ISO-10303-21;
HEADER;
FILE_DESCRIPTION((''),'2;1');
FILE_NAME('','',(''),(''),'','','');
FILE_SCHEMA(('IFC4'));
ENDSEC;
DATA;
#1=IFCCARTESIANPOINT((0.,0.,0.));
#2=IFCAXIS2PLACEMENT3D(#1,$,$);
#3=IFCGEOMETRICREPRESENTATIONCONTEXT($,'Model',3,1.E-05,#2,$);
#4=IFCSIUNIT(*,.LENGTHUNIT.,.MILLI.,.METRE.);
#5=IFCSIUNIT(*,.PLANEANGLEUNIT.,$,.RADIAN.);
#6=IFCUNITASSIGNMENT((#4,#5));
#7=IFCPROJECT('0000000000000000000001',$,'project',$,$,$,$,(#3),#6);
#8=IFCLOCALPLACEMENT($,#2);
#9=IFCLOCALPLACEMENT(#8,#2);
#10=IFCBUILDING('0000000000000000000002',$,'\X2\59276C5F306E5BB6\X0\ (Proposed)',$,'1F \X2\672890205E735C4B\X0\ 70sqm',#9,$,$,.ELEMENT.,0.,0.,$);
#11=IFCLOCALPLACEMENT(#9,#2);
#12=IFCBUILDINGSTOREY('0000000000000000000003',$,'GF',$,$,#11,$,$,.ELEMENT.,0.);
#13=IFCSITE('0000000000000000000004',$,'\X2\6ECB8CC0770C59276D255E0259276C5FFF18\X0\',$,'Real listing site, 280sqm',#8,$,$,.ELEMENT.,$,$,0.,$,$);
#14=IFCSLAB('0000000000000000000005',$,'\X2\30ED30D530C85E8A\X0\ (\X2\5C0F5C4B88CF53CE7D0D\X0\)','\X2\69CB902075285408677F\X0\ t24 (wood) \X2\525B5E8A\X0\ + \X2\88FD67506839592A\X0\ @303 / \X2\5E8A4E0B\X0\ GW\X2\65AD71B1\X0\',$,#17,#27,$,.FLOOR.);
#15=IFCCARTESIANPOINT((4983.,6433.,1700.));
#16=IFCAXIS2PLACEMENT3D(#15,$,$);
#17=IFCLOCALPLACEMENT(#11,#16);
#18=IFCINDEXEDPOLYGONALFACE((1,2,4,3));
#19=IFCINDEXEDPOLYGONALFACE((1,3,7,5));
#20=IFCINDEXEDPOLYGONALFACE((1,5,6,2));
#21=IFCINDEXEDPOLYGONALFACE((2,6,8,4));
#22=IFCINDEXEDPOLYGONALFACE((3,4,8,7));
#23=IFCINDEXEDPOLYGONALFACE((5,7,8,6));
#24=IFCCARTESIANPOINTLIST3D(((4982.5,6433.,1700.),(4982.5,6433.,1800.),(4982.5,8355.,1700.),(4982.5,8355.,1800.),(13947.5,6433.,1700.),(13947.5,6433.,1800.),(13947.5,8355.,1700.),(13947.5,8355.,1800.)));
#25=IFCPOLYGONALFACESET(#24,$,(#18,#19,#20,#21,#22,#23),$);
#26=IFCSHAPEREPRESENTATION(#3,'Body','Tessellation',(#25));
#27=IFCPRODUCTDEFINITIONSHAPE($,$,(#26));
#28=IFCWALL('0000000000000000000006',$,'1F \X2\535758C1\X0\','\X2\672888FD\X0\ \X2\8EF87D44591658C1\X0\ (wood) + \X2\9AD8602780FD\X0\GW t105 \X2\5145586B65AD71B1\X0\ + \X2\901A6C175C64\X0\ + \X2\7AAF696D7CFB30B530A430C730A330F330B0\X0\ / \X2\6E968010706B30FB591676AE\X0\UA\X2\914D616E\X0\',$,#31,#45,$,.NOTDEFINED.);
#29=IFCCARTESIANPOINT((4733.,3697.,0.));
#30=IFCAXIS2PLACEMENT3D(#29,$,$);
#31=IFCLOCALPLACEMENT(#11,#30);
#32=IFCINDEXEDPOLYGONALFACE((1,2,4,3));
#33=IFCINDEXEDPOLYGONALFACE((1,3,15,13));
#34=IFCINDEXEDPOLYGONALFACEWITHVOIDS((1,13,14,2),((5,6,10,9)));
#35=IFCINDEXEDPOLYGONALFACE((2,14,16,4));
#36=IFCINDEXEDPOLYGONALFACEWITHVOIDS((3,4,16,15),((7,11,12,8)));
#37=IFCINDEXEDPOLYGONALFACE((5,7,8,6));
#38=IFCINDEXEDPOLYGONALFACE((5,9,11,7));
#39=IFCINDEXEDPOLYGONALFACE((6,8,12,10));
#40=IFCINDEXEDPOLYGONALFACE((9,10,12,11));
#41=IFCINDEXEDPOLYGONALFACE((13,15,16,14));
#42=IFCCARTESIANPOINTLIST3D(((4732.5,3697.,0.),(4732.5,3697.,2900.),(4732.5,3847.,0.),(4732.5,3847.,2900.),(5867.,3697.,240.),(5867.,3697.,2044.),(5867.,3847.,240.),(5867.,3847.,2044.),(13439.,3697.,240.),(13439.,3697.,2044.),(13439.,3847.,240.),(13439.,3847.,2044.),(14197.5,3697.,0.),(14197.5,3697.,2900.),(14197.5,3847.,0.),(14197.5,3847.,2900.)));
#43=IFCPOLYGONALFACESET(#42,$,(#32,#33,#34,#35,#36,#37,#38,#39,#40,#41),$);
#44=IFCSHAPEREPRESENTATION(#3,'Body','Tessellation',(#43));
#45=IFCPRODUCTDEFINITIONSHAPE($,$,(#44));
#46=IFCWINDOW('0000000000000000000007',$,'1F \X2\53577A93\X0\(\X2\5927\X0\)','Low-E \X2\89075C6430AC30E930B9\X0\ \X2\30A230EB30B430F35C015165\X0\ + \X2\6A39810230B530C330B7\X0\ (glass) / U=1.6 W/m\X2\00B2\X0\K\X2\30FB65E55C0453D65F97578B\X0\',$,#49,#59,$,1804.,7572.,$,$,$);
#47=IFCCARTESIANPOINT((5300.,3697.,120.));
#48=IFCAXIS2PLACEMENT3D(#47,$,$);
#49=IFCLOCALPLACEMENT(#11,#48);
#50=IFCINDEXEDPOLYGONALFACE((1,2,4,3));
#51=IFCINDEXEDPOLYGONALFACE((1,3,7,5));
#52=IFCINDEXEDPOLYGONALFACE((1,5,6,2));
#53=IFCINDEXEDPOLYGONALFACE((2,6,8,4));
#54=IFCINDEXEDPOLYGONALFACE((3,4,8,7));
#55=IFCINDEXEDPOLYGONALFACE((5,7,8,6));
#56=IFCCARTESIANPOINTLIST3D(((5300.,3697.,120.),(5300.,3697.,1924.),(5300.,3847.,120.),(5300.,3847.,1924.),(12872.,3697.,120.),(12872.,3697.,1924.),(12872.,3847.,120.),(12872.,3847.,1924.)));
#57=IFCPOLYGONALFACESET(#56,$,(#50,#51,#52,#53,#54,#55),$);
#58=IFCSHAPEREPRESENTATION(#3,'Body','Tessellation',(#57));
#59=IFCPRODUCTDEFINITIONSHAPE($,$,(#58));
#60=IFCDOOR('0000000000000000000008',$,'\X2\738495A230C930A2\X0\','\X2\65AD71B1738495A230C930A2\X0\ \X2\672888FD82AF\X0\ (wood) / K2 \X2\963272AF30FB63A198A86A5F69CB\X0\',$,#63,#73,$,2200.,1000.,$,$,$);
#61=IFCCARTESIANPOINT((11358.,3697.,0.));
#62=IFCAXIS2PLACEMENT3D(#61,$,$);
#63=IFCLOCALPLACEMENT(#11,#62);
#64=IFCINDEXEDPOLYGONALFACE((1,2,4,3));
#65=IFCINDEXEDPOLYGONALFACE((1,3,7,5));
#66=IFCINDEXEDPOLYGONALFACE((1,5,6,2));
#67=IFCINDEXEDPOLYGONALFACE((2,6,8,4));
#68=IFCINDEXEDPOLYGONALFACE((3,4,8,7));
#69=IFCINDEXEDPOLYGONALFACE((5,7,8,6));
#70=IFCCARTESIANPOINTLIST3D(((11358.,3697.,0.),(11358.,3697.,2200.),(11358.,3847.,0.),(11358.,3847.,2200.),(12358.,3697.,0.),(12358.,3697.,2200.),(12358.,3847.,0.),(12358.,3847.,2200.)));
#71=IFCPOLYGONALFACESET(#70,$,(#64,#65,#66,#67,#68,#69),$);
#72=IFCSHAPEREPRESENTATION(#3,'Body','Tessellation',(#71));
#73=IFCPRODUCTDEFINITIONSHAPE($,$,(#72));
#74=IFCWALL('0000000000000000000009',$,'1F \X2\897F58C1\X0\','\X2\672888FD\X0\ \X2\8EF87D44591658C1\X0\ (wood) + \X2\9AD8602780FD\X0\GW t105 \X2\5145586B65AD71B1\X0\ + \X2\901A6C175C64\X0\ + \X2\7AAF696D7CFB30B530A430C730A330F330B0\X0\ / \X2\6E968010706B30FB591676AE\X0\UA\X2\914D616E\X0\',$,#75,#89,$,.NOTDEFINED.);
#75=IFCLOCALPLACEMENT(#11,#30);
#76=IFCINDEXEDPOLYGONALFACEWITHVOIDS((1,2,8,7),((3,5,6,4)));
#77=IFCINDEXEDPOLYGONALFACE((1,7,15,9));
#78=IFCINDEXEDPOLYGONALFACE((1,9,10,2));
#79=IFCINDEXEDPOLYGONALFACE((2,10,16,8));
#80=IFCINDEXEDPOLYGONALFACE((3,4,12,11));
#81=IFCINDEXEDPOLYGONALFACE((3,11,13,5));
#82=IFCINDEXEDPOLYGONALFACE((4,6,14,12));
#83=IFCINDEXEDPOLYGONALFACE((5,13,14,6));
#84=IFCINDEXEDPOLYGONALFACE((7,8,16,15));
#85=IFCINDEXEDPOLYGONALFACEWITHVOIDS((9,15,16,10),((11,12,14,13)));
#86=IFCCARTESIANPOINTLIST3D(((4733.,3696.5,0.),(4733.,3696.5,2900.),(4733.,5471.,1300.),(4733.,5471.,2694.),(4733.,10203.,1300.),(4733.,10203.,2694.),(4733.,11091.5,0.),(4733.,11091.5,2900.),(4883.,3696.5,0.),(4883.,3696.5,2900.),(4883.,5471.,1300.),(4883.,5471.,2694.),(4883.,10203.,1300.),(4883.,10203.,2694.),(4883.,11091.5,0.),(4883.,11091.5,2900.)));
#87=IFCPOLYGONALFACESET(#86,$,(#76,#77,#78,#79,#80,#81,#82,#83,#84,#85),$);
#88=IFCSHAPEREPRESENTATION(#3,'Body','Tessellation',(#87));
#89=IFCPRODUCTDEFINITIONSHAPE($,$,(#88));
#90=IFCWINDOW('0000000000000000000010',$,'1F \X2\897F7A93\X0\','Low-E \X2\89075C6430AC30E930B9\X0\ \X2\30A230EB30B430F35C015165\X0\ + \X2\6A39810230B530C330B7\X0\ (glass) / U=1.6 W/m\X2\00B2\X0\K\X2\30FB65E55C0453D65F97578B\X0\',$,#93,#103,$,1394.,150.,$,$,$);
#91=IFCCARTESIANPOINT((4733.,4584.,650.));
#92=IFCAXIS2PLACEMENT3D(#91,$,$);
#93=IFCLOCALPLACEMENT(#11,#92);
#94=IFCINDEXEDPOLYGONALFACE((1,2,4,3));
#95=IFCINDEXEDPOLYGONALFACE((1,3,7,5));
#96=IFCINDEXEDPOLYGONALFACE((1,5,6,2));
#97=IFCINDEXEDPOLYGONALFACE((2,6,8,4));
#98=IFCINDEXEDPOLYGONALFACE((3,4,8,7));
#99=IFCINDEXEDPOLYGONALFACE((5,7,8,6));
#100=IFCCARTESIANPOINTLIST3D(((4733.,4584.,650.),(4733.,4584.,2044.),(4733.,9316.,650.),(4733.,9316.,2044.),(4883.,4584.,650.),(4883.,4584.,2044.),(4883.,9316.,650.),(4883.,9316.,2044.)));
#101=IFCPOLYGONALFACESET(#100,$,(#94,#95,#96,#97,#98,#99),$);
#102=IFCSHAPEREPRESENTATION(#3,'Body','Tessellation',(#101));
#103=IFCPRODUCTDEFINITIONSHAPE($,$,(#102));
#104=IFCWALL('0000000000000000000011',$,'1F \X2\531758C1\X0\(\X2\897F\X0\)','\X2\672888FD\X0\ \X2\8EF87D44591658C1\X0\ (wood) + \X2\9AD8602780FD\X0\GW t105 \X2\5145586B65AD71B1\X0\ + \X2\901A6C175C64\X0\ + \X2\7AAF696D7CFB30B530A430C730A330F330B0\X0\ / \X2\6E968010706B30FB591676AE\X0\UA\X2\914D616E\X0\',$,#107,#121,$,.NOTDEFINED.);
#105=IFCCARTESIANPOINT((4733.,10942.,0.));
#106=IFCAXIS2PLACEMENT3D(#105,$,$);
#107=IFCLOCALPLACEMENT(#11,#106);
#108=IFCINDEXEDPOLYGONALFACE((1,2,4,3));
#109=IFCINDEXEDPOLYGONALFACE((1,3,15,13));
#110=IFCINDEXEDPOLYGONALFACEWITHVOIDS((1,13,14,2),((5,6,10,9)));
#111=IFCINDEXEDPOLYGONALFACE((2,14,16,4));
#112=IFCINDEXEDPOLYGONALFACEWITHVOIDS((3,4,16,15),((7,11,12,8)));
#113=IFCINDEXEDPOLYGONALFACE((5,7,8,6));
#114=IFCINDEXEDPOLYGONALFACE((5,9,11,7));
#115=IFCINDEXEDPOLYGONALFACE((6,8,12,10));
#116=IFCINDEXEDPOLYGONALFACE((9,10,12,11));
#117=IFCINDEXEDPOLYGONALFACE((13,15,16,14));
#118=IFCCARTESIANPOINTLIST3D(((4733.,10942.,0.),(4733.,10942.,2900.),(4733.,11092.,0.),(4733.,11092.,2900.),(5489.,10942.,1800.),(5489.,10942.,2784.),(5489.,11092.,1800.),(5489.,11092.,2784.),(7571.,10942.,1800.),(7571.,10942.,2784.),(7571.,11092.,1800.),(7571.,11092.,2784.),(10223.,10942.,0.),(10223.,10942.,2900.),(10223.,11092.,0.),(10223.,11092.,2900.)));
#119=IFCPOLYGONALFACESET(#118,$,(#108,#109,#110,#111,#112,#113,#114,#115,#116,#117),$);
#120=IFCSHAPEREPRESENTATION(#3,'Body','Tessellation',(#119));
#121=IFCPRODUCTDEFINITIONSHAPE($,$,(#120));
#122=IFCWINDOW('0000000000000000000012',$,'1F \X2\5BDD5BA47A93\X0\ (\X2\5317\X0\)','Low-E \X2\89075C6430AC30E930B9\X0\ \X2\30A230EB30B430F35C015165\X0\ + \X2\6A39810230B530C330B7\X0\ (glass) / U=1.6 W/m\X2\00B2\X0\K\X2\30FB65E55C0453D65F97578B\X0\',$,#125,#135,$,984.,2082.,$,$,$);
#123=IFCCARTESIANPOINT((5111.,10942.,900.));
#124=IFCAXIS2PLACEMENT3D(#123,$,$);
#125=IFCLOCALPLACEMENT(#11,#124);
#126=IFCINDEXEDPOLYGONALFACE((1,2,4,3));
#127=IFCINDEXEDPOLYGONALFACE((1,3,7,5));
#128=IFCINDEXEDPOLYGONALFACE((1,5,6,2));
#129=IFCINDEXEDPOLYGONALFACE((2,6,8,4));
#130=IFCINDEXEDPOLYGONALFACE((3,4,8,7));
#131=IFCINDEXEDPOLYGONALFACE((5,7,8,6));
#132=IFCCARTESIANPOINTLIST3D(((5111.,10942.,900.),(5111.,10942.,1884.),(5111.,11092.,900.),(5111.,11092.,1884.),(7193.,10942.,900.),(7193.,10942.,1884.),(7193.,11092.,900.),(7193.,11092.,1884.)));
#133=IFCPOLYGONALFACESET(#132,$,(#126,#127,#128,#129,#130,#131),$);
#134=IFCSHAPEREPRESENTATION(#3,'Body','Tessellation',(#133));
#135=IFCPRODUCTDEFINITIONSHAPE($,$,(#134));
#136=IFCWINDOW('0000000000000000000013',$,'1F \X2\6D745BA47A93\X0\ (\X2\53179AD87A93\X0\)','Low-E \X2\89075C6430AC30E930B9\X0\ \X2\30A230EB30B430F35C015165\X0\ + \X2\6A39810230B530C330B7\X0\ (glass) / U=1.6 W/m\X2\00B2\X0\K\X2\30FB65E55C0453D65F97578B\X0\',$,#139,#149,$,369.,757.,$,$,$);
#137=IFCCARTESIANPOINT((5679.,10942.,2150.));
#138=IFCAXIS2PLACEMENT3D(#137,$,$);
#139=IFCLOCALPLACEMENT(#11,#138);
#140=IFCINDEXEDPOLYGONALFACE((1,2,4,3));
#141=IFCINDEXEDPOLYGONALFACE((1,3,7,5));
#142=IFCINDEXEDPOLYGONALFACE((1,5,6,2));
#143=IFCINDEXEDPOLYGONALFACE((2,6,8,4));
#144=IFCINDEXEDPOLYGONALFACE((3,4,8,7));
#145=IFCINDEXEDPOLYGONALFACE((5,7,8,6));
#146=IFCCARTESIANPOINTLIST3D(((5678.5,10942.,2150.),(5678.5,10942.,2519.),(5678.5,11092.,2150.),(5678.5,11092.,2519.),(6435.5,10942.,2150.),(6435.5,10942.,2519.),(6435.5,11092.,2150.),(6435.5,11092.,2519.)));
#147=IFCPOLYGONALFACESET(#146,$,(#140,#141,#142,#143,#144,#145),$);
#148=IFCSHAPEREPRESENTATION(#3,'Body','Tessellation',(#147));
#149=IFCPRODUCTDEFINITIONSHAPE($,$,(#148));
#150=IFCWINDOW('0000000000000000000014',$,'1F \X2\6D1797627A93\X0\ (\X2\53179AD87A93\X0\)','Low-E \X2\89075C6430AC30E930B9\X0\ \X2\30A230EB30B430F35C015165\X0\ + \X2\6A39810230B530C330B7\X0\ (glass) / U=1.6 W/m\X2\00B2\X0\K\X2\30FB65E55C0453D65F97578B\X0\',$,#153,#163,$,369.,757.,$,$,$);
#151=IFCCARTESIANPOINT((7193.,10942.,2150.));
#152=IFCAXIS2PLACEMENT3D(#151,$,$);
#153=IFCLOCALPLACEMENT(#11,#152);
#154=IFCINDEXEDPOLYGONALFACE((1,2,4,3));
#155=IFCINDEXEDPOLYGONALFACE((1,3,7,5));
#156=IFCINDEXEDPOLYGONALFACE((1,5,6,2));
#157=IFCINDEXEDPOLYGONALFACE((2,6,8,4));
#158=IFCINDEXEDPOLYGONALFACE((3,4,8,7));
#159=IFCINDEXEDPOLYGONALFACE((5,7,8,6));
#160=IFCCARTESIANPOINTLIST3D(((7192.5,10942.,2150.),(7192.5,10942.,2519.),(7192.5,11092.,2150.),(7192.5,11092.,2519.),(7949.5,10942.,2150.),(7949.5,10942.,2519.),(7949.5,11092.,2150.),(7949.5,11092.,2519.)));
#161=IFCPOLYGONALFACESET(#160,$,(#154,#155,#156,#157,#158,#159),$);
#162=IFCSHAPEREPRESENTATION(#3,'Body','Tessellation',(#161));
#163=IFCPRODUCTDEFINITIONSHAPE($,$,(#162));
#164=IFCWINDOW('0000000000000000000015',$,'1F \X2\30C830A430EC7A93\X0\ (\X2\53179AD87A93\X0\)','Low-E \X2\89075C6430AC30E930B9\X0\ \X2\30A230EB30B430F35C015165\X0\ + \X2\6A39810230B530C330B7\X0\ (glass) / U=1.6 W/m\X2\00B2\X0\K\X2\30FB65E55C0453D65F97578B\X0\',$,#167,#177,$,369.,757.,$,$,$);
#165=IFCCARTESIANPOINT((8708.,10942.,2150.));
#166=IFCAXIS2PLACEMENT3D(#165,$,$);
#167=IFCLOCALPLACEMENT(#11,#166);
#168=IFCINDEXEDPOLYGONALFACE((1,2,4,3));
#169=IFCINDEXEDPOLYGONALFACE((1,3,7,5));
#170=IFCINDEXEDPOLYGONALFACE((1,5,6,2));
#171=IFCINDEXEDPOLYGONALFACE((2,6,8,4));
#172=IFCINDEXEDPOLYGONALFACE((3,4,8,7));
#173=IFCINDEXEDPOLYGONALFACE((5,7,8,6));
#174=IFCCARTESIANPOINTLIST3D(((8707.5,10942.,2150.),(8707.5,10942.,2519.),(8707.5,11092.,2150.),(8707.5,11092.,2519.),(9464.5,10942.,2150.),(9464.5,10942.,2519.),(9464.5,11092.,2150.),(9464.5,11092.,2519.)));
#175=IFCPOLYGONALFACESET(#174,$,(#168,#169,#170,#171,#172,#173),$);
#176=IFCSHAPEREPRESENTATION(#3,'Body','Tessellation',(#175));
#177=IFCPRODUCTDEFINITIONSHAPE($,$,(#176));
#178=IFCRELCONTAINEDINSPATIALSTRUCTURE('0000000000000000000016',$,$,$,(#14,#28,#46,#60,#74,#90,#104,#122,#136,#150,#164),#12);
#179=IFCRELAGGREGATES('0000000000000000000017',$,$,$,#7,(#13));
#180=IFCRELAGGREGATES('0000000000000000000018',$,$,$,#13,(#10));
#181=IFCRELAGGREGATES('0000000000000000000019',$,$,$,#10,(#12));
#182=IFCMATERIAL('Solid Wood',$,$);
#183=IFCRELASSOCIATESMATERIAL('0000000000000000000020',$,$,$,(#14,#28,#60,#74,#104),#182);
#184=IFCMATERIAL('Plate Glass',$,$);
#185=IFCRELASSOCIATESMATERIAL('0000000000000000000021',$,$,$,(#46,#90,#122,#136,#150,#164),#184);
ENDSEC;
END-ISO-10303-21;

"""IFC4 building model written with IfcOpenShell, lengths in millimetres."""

from ifc_helpers import new_model, si_unit, frame, frame_2d, origin, place, context, project, spatial, rectangle, extrude, material, element, fill, save


model = new_model("IFC4")

# Units and contexts
model_context = context("Model", 3, precision=1e-05, world=origin())
ifc_project = project(units=[si_unit("LENGTHUNIT", "METRE", prefix="MILLI"), si_unit("PLANEANGLEUNIT", "RADIAN")], contexts=[model_context])

# Site, building, storey
site_placement = place(None, origin())
site = spatial("IfcSite", under=ifc_project, at=site_placement, Name="滋賀県大津市大江８", ObjectType="Real listing site, 280sqm", CompositionType="ELEMENT", RefElevation=0.0)
building_placement = place(site_placement, origin())
building = spatial("IfcBuilding", under=site, at=building_placement, Name="大江の家 (Proposed)", ObjectType="1F 木造平屋 70sqm", CompositionType="ELEMENT", ElevationOfRefHeight=0.0, ElevationOfTerrain=0.0)
storey_placement = place(building_placement, origin())
storey = spatial("IfcBuildingStorey", under=building, at=storey_placement, Name="GF", CompositionType="ELEMENT", Elevation=0.0)

# Slab
ifc_material_1 = material(Name="Solid Wood")
slab_1_placement = place(storey_placement, frame((4983.0, 6433.0, 1700.0)))
element("IfcSlab", 1, at=slab_1_placement, inside=storey, material=ifc_material_1, Name="ロフト床 (小屋裏収納)", Description="構造用合板 t24 (wood) 剛床 + 製材根太 @303 / 床下 GW断熱", PredefinedType="FLOOR", context=model_context, shape_type="SweptSolid", body=[
    extrude(rectangle(XDim=8965.0, YDim=1922.0, at=frame_2d((4482.0, 961.0))), frame((4983.0, 6433.0, 1700.0)), (0.0, 0.0, 1.0), 100.0),
])

# Wall, openings, window, door
wall_1_placement = place(storey_placement, frame((4733.0, 3697.0, 0.0)))
wall_1 = element("IfcWall", 2, at=wall_1_placement, inside=storey, material=ifc_material_1, Name="1F 南壁", Description="木製 軸組外壁 (wood) + 高性能GW t105 充填断熱 + 通気層 + 窯業系サイディング / 準耐火・外皮UA配慮", PredefinedType="NOTDEFINED", context=model_context, shape_type="SweptSolid", body=[
    extrude(rectangle(XDim=9465.0, YDim=150.0, at=frame_2d((4732.0, 75.0))), frame((4733.0, 3697.0, 0.0)), (0.0, 0.0, 1.0), 2900.0),
])
opening_1_placement = place(storey_placement, frame((5300.0, 3697.0, 120.0)))
opening_1 = element("IfcOpeningElement", 3, at=opening_1_placement, cuts=wall_1, PredefinedType="NOTDEFINED", context=model_context, shape_type="SweptSolid", body=[
    extrude(rectangle(XDim=7572.0, YDim=150.0, at=frame_2d((3786.0, 75.0))), frame((5300.0, 3697.0, 120.0)), (0.0, 0.0, 1.0), 1804.0),
])
opening_2_placement = place(storey_placement, frame((11358.0, 3697.0, 0.0)))
opening_2 = element("IfcOpeningElement", 4, at=opening_2_placement, cuts=wall_1, PredefinedType="NOTDEFINED", context=model_context, shape_type="SweptSolid", body=[
    extrude(rectangle(XDim=1000.0, YDim=150.0, at=frame_2d((500.0, 75.0))), frame((11358.0, 3697.0, 0.0)), (0.0, 0.0, 1.0), 2200.0),
])
ifc_material_2 = material(Name="Plate Glass")
window_1_placement = place(storey_placement, frame((5300.0, 3697.0, 120.0)))
window_1 = element("IfcWindow", 5, at=window_1_placement, inside=storey, material=ifc_material_2, Name="1F 南窓(大)", Description="Low-E 複層ガラス アルゴン封入 + 樹脂サッシ (glass) / U=1.6 W/m²K・日射取得型", OverallHeight=1804.0, OverallWidth=7572.0, context=model_context, shape_type="SweptSolid", body=[
    extrude(rectangle(XDim=7572.0, YDim=150.0, at=frame_2d((3786.0, 75.0))), frame((5300.0, 3697.0, 120.0)), (0.0, 0.0, 1.0), 1804.0),
])
fill(opening_1, window_1)
door_placement = place(storey_placement, frame((11358.0, 3697.0, 0.0)))
door = element("IfcDoor", 6, at=door_placement, inside=storey, material=ifc_material_1, Name="玄関ドア", Description="断熱玄関ドア 木製芯 (wood) / K2 防犯・採風機構", OverallHeight=2200.0, OverallWidth=1000.0, context=model_context, shape_type="SweptSolid", body=[
    extrude(rectangle(XDim=1000.0, YDim=150.0, at=frame_2d((500.0, 75.0))), frame((11358.0, 3697.0, 0.0)), (0.0, 0.0, 1.0), 2200.0),
])
fill(opening_2, door)

# Wall, opening, window
wall_2_placement = place(storey_placement, frame((4733.0, 3697.0, 0.0)))
wall_2 = element("IfcWall", 7, at=wall_2_placement, inside=storey, material=ifc_material_1, Name="1F 西壁", Description="木製 軸組外壁 (wood) + 高性能GW t105 充填断熱 + 通気層 + 窯業系サイディング / 準耐火・外皮UA配慮", PredefinedType="NOTDEFINED", context=model_context, shape_type="SweptSolid", body=[
    extrude(rectangle(XDim=150.0, YDim=7395.0, at=frame_2d((75.0, 3697.0))), frame((4733.0, 3697.0, 0.0)), (0.0, 0.0, 1.0), 2900.0),
])
opening_3_placement = place(storey_placement, frame((4733.0, 4584.0, 650.0)))
opening_3 = element("IfcOpeningElement", 8, at=opening_3_placement, cuts=wall_2, PredefinedType="NOTDEFINED", context=model_context, shape_type="SweptSolid", body=[
    extrude(rectangle(XDim=150.0, YDim=4732.0, at=frame_2d((75.0, 2366.0))), frame((4733.0, 4584.0, 650.0)), (0.0, 0.0, 1.0), 1394.0),
])
window_2_placement = place(storey_placement, frame((4733.0, 4584.0, 650.0)))
window_2 = element("IfcWindow", 9, at=window_2_placement, inside=storey, material=ifc_material_2, Name="1F 西窓", Description="Low-E 複層ガラス アルゴン封入 + 樹脂サッシ (glass) / U=1.6 W/m²K・日射取得型", OverallHeight=1394.0, OverallWidth=150.0, context=model_context, shape_type="SweptSolid", body=[
    extrude(rectangle(XDim=150.0, YDim=4732.0, at=frame_2d((75.0, 2366.0))), frame((4733.0, 4584.0, 650.0)), (0.0, 0.0, 1.0), 1394.0),
])
fill(opening_3, window_2)

# Wall, openings, windows
wall_3_placement = place(storey_placement, frame((4733.0, 10942.0, 0.0)))
wall_3 = element("IfcWall", 10, at=wall_3_placement, inside=storey, material=ifc_material_1, Name="1F 北壁(西)", Description="木製 軸組外壁 (wood) + 高性能GW t105 充填断熱 + 通気層 + 窯業系サイディング / 準耐火・外皮UA配慮", PredefinedType="NOTDEFINED", context=model_context, shape_type="SweptSolid", body=[
    extrude(rectangle(XDim=5490.0, YDim=150.0, at=frame_2d((2745.0, 75.0))), frame((4733.0, 10942.0, 0.0)), (0.0, 0.0, 1.0), 2900.0),
])
opening_4_placement = place(storey_placement, frame((5111.0, 10942.0, 900.0)))
opening_4 = element("IfcOpeningElement", 11, at=opening_4_placement, cuts=wall_3, PredefinedType="NOTDEFINED", context=model_context, shape_type="SweptSolid", body=[
    extrude(rectangle(XDim=2082.0, YDim=150.0, at=frame_2d((1041.0, 75.0))), frame((5111.0, 10942.0, 900.0)), (0.0, 0.0, 1.0), 984.0),
])
opening_5_placement = place(storey_placement, frame((5679.0, 10942.0, 2150.0)))
opening_5 = element("IfcOpeningElement", 12, at=opening_5_placement, cuts=wall_3, PredefinedType="NOTDEFINED", context=model_context, shape_type="SweptSolid", body=[
    extrude(rectangle(XDim=757.0, YDim=150.0, at=frame_2d((378.0, 75.0))), frame((5679.0, 10942.0, 2150.0)), (0.0, 0.0, 1.0), 369.0),
])
opening_6_placement = place(storey_placement, frame((7193.0, 10942.0, 2150.0)))
opening_6 = element("IfcOpeningElement", 13, at=opening_6_placement, cuts=wall_3, PredefinedType="NOTDEFINED", context=model_context, shape_type="SweptSolid", body=[
    extrude(rectangle(XDim=757.0, YDim=150.0, at=frame_2d((378.0, 75.0))), frame((7193.0, 10942.0, 2150.0)), (0.0, 0.0, 1.0), 369.0),
])
opening_7_placement = place(storey_placement, frame((8708.0, 10942.0, 2150.0)))
opening_7 = element("IfcOpeningElement", 14, at=opening_7_placement, cuts=wall_3, PredefinedType="NOTDEFINED", context=model_context, shape_type="SweptSolid", body=[
    extrude(rectangle(XDim=757.0, YDim=150.0, at=frame_2d((378.0, 75.0))), frame((8708.0, 10942.0, 2150.0)), (0.0, 0.0, 1.0), 369.0),
])
window_3_placement = place(storey_placement, frame((5111.0, 10942.0, 900.0)))
window_3 = element("IfcWindow", 15, at=window_3_placement, inside=storey, material=ifc_material_2, Name="1F 寝室窓 (北)", Description="Low-E 複層ガラス アルゴン封入 + 樹脂サッシ (glass) / U=1.6 W/m²K・日射取得型", OverallHeight=984.0, OverallWidth=2082.0, context=model_context, shape_type="SweptSolid", body=[
    extrude(rectangle(XDim=2082.0, YDim=150.0, at=frame_2d((1041.0, 75.0))), frame((5111.0, 10942.0, 900.0)), (0.0, 0.0, 1.0), 984.0),
])
fill(opening_4, window_3)
window_4_placement = place(storey_placement, frame((5679.0, 10942.0, 2150.0)))
window_4 = element("IfcWindow", 16, at=window_4_placement, inside=storey, material=ifc_material_2, Name="1F 浴室窓 (北高窓)", Description="Low-E 複層ガラス アルゴン封入 + 樹脂サッシ (glass) / U=1.6 W/m²K・日射取得型", OverallHeight=369.0, OverallWidth=757.0, context=model_context, shape_type="SweptSolid", body=[
    extrude(rectangle(XDim=757.0, YDim=150.0, at=frame_2d((378.0, 75.0))), frame((5679.0, 10942.0, 2150.0)), (0.0, 0.0, 1.0), 369.0),
])
fill(opening_5, window_4)
window_5_placement = place(storey_placement, frame((7193.0, 10942.0, 2150.0)))
window_5 = element("IfcWindow", 17, at=window_5_placement, inside=storey, material=ifc_material_2, Name="1F 洗面窓 (北高窓)", Description="Low-E 複層ガラス アルゴン封入 + 樹脂サッシ (glass) / U=1.6 W/m²K・日射取得型", OverallHeight=369.0, OverallWidth=757.0, context=model_context, shape_type="SweptSolid", body=[
    extrude(rectangle(XDim=757.0, YDim=150.0, at=frame_2d((378.0, 75.0))), frame((7193.0, 10942.0, 2150.0)), (0.0, 0.0, 1.0), 369.0),
])
fill(opening_6, window_5)
window_6_placement = place(storey_placement, frame((8708.0, 10942.0, 2150.0)))
window_6 = element("IfcWindow", 18, at=window_6_placement, inside=storey, material=ifc_material_2, Name="1F トイレ窓 (北高窓)", Description="Low-E 複層ガラス アルゴン封入 + 樹脂サッシ (glass) / U=1.6 W/m²K・日射取得型", OverallHeight=369.0, OverallWidth=757.0, context=model_context, shape_type="SweptSolid", body=[
    extrude(rectangle(XDim=757.0, YDim=150.0, at=frame_2d((378.0, 75.0))), frame((8708.0, 10942.0, 2150.0)), (0.0, 0.0, 1.0), 369.0),
])
fill(opening_7, window_6)

save(model, "model.ifc")
